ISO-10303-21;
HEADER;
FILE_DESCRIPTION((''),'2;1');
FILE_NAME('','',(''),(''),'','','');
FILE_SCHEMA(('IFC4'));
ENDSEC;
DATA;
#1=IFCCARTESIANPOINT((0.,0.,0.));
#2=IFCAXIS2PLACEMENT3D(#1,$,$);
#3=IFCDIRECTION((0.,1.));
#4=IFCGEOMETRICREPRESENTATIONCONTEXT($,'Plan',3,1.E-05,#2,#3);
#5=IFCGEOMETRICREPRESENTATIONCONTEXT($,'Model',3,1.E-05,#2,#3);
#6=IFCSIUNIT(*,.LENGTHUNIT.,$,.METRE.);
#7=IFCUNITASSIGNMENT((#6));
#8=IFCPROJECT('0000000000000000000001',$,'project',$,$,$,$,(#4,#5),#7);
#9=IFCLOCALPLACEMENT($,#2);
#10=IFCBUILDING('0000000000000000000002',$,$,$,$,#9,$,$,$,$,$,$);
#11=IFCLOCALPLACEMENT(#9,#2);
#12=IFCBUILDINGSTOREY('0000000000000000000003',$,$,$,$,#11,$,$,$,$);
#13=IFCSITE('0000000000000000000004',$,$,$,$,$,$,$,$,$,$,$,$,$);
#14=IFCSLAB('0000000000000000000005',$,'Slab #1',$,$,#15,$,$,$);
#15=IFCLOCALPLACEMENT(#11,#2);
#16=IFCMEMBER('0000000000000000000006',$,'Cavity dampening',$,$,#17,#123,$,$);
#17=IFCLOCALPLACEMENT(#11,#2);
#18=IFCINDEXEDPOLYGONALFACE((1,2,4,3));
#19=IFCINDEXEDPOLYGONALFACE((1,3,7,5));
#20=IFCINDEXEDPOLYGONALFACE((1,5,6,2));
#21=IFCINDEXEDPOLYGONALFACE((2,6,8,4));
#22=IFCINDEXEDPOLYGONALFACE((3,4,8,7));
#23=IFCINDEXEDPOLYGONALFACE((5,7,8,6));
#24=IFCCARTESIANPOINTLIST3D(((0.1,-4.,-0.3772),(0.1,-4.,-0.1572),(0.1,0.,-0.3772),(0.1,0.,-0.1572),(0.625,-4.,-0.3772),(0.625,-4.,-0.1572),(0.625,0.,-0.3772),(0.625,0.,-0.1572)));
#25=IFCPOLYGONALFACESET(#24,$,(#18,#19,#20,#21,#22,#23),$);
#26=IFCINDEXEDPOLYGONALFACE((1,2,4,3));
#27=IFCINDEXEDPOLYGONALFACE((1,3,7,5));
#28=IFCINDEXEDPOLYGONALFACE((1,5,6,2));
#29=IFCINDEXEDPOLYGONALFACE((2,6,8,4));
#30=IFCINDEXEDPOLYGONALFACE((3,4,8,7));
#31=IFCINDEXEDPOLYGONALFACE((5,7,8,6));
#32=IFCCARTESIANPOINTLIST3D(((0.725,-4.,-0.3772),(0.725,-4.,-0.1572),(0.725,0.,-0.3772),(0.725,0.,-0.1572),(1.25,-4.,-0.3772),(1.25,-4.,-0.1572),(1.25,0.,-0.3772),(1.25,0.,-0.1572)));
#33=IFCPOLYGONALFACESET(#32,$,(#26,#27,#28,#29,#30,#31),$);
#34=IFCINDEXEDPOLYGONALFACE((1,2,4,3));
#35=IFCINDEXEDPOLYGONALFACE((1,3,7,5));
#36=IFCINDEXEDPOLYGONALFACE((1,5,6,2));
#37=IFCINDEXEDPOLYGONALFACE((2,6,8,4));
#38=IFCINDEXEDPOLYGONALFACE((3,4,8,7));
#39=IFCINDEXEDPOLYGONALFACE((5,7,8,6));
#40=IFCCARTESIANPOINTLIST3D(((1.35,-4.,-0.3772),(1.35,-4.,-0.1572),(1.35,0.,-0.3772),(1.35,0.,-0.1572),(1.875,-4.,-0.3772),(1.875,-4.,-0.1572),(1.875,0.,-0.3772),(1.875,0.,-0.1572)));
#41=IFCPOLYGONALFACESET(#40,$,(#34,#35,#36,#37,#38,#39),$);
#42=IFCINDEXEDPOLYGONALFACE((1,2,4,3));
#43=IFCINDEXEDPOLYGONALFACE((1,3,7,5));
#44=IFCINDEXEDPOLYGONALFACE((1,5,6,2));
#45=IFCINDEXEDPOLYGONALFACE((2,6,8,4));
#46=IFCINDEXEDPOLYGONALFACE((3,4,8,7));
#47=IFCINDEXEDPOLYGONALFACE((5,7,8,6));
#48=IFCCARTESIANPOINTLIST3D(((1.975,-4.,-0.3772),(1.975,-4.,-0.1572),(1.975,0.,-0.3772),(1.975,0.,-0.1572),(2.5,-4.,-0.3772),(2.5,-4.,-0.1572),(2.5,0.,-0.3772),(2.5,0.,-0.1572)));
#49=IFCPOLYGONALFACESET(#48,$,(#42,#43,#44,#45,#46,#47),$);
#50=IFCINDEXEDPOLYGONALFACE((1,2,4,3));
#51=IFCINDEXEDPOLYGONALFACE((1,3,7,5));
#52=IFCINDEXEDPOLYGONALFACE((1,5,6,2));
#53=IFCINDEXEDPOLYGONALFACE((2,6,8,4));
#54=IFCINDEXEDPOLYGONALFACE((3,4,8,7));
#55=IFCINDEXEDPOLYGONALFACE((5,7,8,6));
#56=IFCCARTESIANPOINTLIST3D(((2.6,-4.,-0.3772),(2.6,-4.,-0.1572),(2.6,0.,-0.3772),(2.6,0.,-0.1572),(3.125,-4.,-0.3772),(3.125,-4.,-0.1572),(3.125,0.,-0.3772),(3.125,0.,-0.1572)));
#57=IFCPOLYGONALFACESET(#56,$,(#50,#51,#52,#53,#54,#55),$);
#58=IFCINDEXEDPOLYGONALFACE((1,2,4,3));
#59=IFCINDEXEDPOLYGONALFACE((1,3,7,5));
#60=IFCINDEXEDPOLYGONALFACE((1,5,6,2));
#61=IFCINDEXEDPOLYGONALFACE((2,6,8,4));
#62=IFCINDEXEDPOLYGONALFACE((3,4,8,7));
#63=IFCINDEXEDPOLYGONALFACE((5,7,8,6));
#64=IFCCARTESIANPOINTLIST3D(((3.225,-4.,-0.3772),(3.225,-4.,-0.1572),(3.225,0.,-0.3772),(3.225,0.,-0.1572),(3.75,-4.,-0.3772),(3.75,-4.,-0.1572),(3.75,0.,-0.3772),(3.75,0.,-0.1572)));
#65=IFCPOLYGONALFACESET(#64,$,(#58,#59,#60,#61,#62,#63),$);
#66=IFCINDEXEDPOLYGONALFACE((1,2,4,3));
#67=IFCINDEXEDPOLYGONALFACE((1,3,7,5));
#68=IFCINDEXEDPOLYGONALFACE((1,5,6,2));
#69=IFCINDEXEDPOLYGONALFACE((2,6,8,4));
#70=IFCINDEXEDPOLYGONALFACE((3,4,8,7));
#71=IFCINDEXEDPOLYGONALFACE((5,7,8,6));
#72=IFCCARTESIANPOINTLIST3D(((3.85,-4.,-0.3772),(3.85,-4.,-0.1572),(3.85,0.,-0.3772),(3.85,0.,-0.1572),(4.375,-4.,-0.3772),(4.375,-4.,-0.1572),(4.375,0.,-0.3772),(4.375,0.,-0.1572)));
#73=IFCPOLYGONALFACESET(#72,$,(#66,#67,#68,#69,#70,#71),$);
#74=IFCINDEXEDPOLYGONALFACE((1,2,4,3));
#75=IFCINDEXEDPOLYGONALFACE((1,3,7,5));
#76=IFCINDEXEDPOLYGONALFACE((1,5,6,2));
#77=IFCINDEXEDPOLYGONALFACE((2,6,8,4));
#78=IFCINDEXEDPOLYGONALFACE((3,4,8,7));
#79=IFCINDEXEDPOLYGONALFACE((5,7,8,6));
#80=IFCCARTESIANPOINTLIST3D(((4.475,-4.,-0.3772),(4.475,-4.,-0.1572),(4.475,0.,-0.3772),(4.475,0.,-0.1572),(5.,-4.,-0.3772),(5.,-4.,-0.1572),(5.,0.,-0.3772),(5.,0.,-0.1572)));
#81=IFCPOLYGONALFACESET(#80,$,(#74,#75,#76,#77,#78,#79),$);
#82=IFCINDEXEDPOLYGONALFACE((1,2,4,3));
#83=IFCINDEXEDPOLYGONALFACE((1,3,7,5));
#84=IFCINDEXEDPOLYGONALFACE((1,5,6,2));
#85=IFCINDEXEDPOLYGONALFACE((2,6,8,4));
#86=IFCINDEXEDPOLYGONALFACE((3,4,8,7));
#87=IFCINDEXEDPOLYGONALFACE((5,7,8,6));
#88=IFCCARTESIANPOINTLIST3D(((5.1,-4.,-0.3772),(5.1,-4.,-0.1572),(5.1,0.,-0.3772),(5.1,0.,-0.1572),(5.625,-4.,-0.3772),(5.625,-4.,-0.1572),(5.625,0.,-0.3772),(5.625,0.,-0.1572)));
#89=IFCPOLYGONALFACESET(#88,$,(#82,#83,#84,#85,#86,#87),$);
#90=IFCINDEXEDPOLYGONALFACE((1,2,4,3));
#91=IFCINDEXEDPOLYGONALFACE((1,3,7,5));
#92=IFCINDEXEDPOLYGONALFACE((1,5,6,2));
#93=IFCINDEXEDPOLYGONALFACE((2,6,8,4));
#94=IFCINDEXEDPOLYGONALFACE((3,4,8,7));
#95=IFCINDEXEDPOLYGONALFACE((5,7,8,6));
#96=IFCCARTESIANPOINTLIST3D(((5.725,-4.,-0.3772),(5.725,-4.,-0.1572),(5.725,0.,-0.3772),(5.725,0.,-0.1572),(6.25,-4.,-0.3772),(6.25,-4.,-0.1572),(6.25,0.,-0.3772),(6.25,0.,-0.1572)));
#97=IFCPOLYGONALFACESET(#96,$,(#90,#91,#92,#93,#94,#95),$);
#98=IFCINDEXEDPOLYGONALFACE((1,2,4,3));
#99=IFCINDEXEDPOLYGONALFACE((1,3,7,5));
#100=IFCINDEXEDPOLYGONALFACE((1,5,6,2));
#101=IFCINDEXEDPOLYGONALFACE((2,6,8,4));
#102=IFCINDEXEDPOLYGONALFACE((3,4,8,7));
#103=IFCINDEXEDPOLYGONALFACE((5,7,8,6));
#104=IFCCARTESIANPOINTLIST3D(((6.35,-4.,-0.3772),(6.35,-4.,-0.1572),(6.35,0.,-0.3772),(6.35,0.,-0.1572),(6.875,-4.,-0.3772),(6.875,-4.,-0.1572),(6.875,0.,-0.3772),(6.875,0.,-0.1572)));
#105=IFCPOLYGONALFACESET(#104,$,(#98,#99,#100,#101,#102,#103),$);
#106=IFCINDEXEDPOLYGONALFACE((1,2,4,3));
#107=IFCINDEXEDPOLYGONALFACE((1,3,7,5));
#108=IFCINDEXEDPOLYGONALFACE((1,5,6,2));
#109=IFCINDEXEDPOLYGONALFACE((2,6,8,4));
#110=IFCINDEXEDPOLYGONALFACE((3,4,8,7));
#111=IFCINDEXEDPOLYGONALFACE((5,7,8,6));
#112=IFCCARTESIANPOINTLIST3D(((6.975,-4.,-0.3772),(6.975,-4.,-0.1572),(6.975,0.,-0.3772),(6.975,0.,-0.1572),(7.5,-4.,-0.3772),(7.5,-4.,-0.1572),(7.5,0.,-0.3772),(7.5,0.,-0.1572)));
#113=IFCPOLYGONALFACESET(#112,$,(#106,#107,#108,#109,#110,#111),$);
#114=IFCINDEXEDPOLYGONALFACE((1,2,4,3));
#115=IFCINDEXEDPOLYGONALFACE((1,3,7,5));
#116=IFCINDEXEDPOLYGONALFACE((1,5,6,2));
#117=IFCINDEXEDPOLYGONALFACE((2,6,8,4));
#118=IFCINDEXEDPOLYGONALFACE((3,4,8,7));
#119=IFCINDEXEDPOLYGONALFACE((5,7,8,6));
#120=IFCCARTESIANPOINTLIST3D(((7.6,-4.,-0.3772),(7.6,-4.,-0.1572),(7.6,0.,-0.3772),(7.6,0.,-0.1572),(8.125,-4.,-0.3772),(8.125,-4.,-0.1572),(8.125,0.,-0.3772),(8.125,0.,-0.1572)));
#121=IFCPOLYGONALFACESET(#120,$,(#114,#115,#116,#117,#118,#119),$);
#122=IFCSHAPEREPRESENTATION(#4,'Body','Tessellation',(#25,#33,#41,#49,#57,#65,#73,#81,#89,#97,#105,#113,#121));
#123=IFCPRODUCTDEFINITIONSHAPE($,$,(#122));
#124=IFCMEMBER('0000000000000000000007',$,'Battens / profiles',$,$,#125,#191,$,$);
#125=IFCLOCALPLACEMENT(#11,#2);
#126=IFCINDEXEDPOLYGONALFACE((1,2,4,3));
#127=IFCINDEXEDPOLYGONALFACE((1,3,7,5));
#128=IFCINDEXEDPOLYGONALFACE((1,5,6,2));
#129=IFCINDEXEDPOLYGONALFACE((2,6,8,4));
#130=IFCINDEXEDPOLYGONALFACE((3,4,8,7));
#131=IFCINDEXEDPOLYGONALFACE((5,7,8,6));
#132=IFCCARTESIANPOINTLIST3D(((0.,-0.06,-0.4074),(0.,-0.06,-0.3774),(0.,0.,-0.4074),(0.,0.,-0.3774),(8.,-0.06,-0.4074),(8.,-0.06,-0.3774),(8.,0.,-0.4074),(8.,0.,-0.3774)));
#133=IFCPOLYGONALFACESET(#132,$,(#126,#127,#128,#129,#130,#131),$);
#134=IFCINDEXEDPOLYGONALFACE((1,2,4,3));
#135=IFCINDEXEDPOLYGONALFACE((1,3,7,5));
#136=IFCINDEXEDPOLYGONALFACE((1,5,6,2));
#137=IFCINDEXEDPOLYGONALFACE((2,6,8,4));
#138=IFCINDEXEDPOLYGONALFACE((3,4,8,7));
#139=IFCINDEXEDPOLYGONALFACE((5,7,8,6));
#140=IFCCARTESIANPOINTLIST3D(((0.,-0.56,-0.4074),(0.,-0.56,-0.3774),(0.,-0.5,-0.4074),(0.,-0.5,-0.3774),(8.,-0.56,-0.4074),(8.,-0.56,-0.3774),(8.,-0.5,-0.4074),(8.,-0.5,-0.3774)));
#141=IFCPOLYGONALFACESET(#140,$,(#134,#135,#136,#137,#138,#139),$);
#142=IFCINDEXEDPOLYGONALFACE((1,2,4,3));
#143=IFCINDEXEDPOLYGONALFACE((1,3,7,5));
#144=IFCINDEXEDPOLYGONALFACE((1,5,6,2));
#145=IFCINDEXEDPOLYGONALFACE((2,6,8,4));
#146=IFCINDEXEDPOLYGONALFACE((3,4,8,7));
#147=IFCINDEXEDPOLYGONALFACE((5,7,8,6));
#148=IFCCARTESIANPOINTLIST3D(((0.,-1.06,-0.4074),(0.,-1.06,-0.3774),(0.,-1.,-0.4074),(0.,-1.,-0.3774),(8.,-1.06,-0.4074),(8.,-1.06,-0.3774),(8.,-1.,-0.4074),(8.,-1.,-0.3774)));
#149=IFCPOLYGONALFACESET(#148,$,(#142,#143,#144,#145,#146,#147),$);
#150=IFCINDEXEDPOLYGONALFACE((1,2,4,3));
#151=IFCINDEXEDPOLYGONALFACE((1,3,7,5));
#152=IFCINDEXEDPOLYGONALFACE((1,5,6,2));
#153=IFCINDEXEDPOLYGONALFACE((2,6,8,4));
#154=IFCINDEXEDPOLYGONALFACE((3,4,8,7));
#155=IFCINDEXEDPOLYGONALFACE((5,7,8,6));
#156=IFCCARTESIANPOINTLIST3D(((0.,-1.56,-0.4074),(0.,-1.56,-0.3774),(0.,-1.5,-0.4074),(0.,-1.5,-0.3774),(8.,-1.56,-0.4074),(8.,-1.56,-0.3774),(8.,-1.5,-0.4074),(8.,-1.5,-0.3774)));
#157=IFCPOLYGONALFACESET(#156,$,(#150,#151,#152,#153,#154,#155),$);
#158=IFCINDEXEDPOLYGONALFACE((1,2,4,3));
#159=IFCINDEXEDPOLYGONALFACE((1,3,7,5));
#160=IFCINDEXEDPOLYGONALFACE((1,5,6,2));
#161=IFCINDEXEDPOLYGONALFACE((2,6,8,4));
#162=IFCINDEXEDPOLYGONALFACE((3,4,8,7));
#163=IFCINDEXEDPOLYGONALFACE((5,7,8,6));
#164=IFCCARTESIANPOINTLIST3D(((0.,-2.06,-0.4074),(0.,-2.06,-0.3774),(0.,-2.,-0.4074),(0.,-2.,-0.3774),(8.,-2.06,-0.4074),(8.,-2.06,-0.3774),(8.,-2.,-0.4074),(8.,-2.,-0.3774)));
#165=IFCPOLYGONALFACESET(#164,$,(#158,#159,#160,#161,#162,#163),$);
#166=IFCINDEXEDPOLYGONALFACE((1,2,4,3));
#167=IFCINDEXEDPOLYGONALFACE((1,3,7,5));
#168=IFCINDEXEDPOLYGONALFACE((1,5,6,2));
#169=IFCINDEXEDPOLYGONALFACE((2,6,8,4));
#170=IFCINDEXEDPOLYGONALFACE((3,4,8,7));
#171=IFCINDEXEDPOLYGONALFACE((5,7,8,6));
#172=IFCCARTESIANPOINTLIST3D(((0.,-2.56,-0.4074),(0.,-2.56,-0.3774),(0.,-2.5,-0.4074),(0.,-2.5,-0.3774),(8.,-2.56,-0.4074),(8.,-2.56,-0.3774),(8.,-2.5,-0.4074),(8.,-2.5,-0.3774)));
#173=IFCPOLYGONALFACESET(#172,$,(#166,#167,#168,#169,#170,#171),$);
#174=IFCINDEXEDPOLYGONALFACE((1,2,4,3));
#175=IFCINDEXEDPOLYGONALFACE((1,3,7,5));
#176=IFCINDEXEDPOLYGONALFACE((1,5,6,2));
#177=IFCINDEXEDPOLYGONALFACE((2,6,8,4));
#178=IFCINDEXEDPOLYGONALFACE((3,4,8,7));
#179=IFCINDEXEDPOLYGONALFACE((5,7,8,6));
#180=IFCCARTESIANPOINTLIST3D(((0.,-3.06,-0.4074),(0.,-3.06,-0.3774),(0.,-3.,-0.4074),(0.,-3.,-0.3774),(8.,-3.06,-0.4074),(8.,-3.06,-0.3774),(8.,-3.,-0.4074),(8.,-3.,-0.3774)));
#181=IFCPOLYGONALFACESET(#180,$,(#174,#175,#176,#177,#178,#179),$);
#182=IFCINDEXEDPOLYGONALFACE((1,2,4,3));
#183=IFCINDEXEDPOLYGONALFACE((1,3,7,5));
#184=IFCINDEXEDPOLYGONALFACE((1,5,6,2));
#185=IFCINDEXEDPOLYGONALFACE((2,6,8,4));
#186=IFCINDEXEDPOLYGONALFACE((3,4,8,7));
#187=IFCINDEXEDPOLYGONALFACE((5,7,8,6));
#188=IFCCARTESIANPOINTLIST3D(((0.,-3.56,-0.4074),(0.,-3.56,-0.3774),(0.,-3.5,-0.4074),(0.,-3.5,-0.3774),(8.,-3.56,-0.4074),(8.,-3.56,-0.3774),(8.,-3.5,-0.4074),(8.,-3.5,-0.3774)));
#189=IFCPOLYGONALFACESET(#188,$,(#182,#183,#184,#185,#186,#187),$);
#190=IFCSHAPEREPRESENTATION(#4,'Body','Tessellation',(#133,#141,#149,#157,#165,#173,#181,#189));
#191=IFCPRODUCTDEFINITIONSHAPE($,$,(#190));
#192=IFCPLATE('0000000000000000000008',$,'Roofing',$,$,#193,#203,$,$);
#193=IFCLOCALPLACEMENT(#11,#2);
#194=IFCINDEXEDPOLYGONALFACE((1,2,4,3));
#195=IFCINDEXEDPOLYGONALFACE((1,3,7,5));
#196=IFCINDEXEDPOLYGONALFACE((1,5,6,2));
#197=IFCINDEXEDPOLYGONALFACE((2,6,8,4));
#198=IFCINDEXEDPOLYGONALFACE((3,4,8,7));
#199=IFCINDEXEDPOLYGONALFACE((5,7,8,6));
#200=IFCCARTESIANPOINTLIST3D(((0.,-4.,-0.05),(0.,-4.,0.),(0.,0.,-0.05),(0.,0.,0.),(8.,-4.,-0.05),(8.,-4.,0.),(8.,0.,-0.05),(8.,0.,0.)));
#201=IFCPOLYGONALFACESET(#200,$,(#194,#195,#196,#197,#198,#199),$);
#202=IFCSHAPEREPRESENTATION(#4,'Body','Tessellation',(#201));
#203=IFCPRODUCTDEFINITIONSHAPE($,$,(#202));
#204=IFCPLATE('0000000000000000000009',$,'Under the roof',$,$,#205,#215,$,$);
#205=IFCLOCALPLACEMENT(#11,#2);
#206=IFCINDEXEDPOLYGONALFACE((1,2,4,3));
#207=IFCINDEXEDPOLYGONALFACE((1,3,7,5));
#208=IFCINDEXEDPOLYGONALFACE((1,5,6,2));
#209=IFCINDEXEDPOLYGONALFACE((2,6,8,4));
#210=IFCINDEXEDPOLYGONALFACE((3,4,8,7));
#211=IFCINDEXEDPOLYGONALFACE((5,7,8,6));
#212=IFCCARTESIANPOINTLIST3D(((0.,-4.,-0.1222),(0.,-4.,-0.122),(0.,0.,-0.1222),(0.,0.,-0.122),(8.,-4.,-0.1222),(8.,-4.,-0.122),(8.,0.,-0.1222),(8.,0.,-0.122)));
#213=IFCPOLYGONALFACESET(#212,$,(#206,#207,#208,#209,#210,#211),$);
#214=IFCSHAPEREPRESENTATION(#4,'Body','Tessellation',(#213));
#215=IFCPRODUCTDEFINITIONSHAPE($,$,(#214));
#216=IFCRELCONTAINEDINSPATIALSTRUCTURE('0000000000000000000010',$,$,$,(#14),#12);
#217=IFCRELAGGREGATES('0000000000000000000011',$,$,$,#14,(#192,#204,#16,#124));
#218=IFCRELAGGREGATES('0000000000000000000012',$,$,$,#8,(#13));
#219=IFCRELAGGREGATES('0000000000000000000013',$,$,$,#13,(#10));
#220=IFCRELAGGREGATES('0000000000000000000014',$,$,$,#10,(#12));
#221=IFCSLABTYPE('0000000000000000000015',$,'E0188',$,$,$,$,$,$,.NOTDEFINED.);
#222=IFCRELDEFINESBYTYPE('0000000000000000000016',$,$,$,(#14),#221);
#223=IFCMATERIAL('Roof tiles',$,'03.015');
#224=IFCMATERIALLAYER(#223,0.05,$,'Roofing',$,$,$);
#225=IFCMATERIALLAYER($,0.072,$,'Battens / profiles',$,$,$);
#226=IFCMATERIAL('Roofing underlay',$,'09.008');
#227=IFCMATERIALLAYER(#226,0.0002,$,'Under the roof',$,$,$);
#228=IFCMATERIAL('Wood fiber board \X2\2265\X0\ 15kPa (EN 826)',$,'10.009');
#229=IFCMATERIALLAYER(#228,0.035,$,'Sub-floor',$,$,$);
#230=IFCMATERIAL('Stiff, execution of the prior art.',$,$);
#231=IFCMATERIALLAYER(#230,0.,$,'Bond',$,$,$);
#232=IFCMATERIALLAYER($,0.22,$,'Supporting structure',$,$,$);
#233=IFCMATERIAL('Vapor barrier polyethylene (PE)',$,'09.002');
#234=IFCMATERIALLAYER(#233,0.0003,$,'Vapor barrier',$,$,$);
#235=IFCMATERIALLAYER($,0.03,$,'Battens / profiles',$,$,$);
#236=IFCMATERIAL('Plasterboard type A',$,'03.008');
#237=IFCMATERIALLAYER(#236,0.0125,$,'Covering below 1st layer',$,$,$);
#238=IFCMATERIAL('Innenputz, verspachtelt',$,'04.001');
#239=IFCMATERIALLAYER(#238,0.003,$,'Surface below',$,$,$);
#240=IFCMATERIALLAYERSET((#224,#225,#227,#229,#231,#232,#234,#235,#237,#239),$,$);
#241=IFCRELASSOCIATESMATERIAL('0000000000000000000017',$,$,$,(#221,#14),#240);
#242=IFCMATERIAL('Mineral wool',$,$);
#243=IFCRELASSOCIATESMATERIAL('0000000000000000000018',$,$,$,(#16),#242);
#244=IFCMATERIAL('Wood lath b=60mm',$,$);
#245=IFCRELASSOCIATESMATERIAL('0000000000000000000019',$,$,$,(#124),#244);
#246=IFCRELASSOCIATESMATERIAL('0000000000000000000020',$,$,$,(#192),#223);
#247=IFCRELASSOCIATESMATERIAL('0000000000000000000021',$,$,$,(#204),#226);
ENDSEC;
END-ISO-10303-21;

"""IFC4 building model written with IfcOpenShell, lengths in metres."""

from ifc_helpers import new_model, si_unit, direction, frame, frame_2d, origin, origin_with_axes, place, context, project, spatial, rectangle, extrude, material, layer, layer_set, type_object, element, aggregate, save


model = new_model("IFC4")

# Units and contexts
plan_context = context("Plan", 3, precision=1e-05, world=origin(), true_north=direction((0.0, 1.0)))
model_context = context("Model", 3, precision=1e-05, world=origin(), true_north=direction((0.0, 1.0)))
ifc_project = project(units=[si_unit("LENGTHUNIT", "METRE")], contexts=[plan_context, model_context])

# Site, building, storey
site = spatial("IfcSite", under=ifc_project)
building_placement = place(None, origin())
building = spatial("IfcBuilding", under=site, at=building_placement)
storey_placement = place(building_placement, origin())
storey = spatial("IfcBuildingStorey", under=building, at=storey_placement)

# Slab, members, plates
ifc_material_1 = material(Name="Roof tiles", Category="03.015")
ifc_layer_1 = layer(ifc_material_1, 0.05, Name="Roofing")
ifc_layer_2 = layer(None, 0.072, Name="Battens / profiles")
ifc_material_2 = material(Name="Roofing underlay", Category="09.008")
ifc_layer_3 = layer(ifc_material_2, 0.0002, Name="Under the roof")
ifc_material_3 = material(Name="Wood fiber board ≥ 15kPa (EN 826)", Category="10.009")
ifc_layer_4 = layer(ifc_material_3, 0.035, Name="Sub-floor")
ifc_material_4 = material(Name="Stiff, execution of the prior art.")
ifc_layer_5 = layer(ifc_material_4, 0.0, Name="Bond")
ifc_layer_6 = layer(None, 0.22, Name="Supporting structure")
ifc_material_5 = material(Name="Vapor barrier polyethylene (PE)", Category="09.002")
ifc_layer_7 = layer(ifc_material_5, 0.0003, Name="Vapor barrier")
ifc_layer_8 = layer(None, 0.03, Name="Battens / profiles")
ifc_material_6 = material(Name="Plasterboard type A", Category="03.008")
ifc_layer_9 = layer(ifc_material_6, 0.0125, Name="Covering below 1st layer")
ifc_material_7 = material(Name="Innenputz, verspachtelt", Category="04.001")
ifc_layer_10 = layer(ifc_material_7, 0.003, Name="Surface below")
ifc_layer_set = layer_set([ifc_layer_1, ifc_layer_2, ifc_layer_3, ifc_layer_4, ifc_layer_5, ifc_layer_6, ifc_layer_7, ifc_layer_8, ifc_layer_9, ifc_layer_10])
slab_type = type_object("IfcSlabType", Name="E0188", PredefinedType="NOTDEFINED", material=ifc_layer_set)
slab_placement = place(None, frame((0.0, 0.0, 0.0), z_axis=(0.0, 0.0, -1.0), x_axis=(1.0, 0.0, 0.0)))
slab = element("IfcSlab", 1, at=slab_placement, inside=storey, type_object=slab_type, material=ifc_layer_set, Name="Slab #1")
ifc_material_8 = material(Name="Mineral wool")
member_1_placement = place(slab_placement, origin())
member_1 = element("IfcMember", 2, at=member_1_placement, material=ifc_material_8, Name="Cavity dampening", context=plan_context, shape_type="SweptSolid", body=[
    extrude(rectangle(XDim=0.525, YDim=0.22, at=frame_2d((0.2625, 0.11), x_axis=(1.0, 0.0))), frame((0.1, 4.0, 0.1572), z_axis=(0.0, -1.0, 0.0), x_axis=(1.0, 0.0, 0.0)), (0.0, 0.0, 1.0), 4.0),
    extrude(rectangle(XDim=0.525, YDim=0.22, at=frame_2d((0.2625, 0.11), x_axis=(1.0, 0.0))), frame((0.725, 4.0, 0.1572), z_axis=(0.0, -1.0, 0.0), x_axis=(1.0, 0.0, 0.0)), (0.0, 0.0, 1.0), 4.0),
    extrude(rectangle(XDim=0.525, YDim=0.22, at=frame_2d((0.2625, 0.11), x_axis=(1.0, 0.0))), frame((1.35, 4.0, 0.1572), z_axis=(0.0, -1.0, 0.0), x_axis=(1.0, 0.0, 0.0)), (0.0, 0.0, 1.0), 4.0),
    extrude(rectangle(XDim=0.525, YDim=0.22, at=frame_2d((0.2625, 0.11), x_axis=(1.0, 0.0))), frame((1.975, 4.0, 0.1572), z_axis=(0.0, -1.0, 0.0), x_axis=(1.0, 0.0, 0.0)), (0.0, 0.0, 1.0), 4.0),
    extrude(rectangle(XDim=0.525, YDim=0.22, at=frame_2d((0.2625, 0.11), x_axis=(1.0, 0.0))), frame((2.6, 4.0, 0.1572), z_axis=(0.0, -1.0, 0.0), x_axis=(1.0, 0.0, 0.0)), (0.0, 0.0, 1.0), 4.0),
    extrude(rectangle(XDim=0.525, YDim=0.22, at=frame_2d((0.2625, 0.11), x_axis=(1.0, 0.0))), frame((3.225, 4.0, 0.1572), z_axis=(0.0, -1.0, 0.0), x_axis=(1.0, 0.0, 0.0)), (0.0, 0.0, 1.0), 4.0),
    extrude(rectangle(XDim=0.525, YDim=0.22, at=frame_2d((0.2625, 0.11), x_axis=(1.0, 0.0))), frame((3.85, 4.0, 0.1572), z_axis=(0.0, -1.0, 0.0), x_axis=(1.0, 0.0, 0.0)), (0.0, 0.0, 1.0), 4.0),
    extrude(rectangle(XDim=0.525, YDim=0.22, at=frame_2d((0.2625, 0.11), x_axis=(1.0, 0.0))), frame((4.475, 4.0, 0.1572), z_axis=(0.0, -1.0, 0.0), x_axis=(1.0, 0.0, 0.0)), (0.0, 0.0, 1.0), 4.0),
    extrude(rectangle(XDim=0.525, YDim=0.22, at=frame_2d((0.2625, 0.11), x_axis=(1.0, 0.0))), frame((5.1, 4.0, 0.1572), z_axis=(0.0, -1.0, 0.0), x_axis=(1.0, 0.0, 0.0)), (0.0, 0.0, 1.0), 4.0),
    extrude(rectangle(XDim=0.525, YDim=0.22, at=frame_2d((0.2625, 0.11), x_axis=(1.0, 0.0))), frame((5.725, 4.0, 0.1572), z_axis=(0.0, -1.0, 0.0), x_axis=(1.0, 0.0, 0.0)), (0.0, 0.0, 1.0), 4.0),
    extrude(rectangle(XDim=0.525, YDim=0.22, at=frame_2d((0.2625, 0.11), x_axis=(1.0, 0.0))), frame((6.35, 4.0, 0.1572), z_axis=(0.0, -1.0, 0.0), x_axis=(1.0, 0.0, 0.0)), (0.0, 0.0, 1.0), 4.0),
    extrude(rectangle(XDim=0.525, YDim=0.22, at=frame_2d((0.2625, 0.11), x_axis=(1.0, 0.0))), frame((6.975, 4.0, 0.1572), z_axis=(0.0, -1.0, 0.0), x_axis=(1.0, 0.0, 0.0)), (0.0, 0.0, 1.0), 4.0),
    extrude(rectangle(XDim=0.525, YDim=0.22, at=frame_2d((0.2625, 0.11), x_axis=(1.0, 0.0))), frame((7.6, 4.0, 0.1572), z_axis=(0.0, -1.0, 0.0), x_axis=(1.0, 0.0, 0.0)), (0.0, 0.0, 1.0), 4.0),
])
ifc_material_9 = material(Name="Wood lath b=60mm")
member_2_placement = place(slab_placement, origin())
member_2 = element("IfcMember", 3, at=member_2_placement, material=ifc_material_9, Name="Battens / profiles", context=plan_context, shape_type="SweptSolid", body=[
    extrude(rectangle(XDim=0.06, YDim=0.03, at=frame_2d((0.03, 0.015), x_axis=(1.0, 0.0))), frame((0.0, 0.0, 0.3774), z_axis=(1.0, 0.0, 0.0), x_axis=(0.0, 1.0, 0.0)), (0.0, 0.0, 1.0), 8.0),
    extrude(rectangle(XDim=0.06, YDim=0.03, at=frame_2d((0.03, 0.015), x_axis=(1.0, 0.0))), frame((0.0, 0.5, 0.3774), z_axis=(1.0, 0.0, 0.0), x_axis=(0.0, 1.0, 0.0)), (0.0, 0.0, 1.0), 8.0),
    extrude(rectangle(XDim=0.06, YDim=0.03, at=frame_2d((0.03, 0.015), x_axis=(1.0, 0.0))), frame((0.0, 1.0, 0.3774), z_axis=(1.0, 0.0, 0.0), x_axis=(0.0, 1.0, 0.0)), (0.0, 0.0, 1.0), 8.0),
    extrude(rectangle(XDim=0.06, YDim=0.03, at=frame_2d((0.03, 0.015), x_axis=(1.0, 0.0))), frame((0.0, 1.5, 0.3774), z_axis=(1.0, 0.0, 0.0), x_axis=(0.0, 1.0, 0.0)), (0.0, 0.0, 1.0), 8.0),
    extrude(rectangle(XDim=0.06, YDim=0.03, at=frame_2d((0.03, 0.015), x_axis=(1.0, 0.0))), frame((0.0, 2.0, 0.3774), z_axis=(1.0, 0.0, 0.0), x_axis=(0.0, 1.0, 0.0)), (0.0, 0.0, 1.0), 8.0),
    extrude(rectangle(XDim=0.06, YDim=0.03, at=frame_2d((0.03, 0.015), x_axis=(1.0, 0.0))), frame((0.0, 2.5, 0.3774), z_axis=(1.0, 0.0, 0.0), x_axis=(0.0, 1.0, 0.0)), (0.0, 0.0, 1.0), 8.0),
    extrude(rectangle(XDim=0.06, YDim=0.03, at=frame_2d((0.03, 0.015), x_axis=(1.0, 0.0))), frame((0.0, 3.0, 0.3774), z_axis=(1.0, 0.0, 0.0), x_axis=(0.0, 1.0, 0.0)), (0.0, 0.0, 1.0), 8.0),
    extrude(rectangle(XDim=0.06, YDim=0.03, at=frame_2d((0.03, 0.015), x_axis=(1.0, 0.0))), frame((0.0, 3.5, 0.3774), z_axis=(1.0, 0.0, 0.0), x_axis=(0.0, 1.0, 0.0)), (0.0, 0.0, 1.0), 8.0),
])
plate_1_placement = place(slab_placement, origin())
plate_1 = element("IfcPlate", 4, at=plate_1_placement, material=ifc_material_1, Name="Roofing", context=plan_context, shape_type="SweptSolid", body=[
    extrude(rectangle(XDim=8.0, YDim=4.0, at=frame_2d((4.0, 2.0), x_axis=(1.0, 0.0))), origin_with_axes(), (0.0, 0.0, 1.0), 0.05),
])
plate_2_placement = place(slab_placement, origin())
plate_2 = element("IfcPlate", 5, at=plate_2_placement, material=ifc_material_2, Name="Under the roof", context=plan_context, shape_type="SweptSolid", body=[
    extrude(rectangle(XDim=8.0, YDim=4.0, at=frame_2d((4.0, 2.0), x_axis=(1.0, 0.0))), frame((0.0, 0.0, 0.122), z_axis=(0.0, 0.0, 1.0), x_axis=(1.0, 0.0, 0.0)), (0.0, 0.0, 1.0), 0.0002),
])
aggregate(slab, [plate_1, plate_2, member_1, member_2])

save(model, "model.ifc")
